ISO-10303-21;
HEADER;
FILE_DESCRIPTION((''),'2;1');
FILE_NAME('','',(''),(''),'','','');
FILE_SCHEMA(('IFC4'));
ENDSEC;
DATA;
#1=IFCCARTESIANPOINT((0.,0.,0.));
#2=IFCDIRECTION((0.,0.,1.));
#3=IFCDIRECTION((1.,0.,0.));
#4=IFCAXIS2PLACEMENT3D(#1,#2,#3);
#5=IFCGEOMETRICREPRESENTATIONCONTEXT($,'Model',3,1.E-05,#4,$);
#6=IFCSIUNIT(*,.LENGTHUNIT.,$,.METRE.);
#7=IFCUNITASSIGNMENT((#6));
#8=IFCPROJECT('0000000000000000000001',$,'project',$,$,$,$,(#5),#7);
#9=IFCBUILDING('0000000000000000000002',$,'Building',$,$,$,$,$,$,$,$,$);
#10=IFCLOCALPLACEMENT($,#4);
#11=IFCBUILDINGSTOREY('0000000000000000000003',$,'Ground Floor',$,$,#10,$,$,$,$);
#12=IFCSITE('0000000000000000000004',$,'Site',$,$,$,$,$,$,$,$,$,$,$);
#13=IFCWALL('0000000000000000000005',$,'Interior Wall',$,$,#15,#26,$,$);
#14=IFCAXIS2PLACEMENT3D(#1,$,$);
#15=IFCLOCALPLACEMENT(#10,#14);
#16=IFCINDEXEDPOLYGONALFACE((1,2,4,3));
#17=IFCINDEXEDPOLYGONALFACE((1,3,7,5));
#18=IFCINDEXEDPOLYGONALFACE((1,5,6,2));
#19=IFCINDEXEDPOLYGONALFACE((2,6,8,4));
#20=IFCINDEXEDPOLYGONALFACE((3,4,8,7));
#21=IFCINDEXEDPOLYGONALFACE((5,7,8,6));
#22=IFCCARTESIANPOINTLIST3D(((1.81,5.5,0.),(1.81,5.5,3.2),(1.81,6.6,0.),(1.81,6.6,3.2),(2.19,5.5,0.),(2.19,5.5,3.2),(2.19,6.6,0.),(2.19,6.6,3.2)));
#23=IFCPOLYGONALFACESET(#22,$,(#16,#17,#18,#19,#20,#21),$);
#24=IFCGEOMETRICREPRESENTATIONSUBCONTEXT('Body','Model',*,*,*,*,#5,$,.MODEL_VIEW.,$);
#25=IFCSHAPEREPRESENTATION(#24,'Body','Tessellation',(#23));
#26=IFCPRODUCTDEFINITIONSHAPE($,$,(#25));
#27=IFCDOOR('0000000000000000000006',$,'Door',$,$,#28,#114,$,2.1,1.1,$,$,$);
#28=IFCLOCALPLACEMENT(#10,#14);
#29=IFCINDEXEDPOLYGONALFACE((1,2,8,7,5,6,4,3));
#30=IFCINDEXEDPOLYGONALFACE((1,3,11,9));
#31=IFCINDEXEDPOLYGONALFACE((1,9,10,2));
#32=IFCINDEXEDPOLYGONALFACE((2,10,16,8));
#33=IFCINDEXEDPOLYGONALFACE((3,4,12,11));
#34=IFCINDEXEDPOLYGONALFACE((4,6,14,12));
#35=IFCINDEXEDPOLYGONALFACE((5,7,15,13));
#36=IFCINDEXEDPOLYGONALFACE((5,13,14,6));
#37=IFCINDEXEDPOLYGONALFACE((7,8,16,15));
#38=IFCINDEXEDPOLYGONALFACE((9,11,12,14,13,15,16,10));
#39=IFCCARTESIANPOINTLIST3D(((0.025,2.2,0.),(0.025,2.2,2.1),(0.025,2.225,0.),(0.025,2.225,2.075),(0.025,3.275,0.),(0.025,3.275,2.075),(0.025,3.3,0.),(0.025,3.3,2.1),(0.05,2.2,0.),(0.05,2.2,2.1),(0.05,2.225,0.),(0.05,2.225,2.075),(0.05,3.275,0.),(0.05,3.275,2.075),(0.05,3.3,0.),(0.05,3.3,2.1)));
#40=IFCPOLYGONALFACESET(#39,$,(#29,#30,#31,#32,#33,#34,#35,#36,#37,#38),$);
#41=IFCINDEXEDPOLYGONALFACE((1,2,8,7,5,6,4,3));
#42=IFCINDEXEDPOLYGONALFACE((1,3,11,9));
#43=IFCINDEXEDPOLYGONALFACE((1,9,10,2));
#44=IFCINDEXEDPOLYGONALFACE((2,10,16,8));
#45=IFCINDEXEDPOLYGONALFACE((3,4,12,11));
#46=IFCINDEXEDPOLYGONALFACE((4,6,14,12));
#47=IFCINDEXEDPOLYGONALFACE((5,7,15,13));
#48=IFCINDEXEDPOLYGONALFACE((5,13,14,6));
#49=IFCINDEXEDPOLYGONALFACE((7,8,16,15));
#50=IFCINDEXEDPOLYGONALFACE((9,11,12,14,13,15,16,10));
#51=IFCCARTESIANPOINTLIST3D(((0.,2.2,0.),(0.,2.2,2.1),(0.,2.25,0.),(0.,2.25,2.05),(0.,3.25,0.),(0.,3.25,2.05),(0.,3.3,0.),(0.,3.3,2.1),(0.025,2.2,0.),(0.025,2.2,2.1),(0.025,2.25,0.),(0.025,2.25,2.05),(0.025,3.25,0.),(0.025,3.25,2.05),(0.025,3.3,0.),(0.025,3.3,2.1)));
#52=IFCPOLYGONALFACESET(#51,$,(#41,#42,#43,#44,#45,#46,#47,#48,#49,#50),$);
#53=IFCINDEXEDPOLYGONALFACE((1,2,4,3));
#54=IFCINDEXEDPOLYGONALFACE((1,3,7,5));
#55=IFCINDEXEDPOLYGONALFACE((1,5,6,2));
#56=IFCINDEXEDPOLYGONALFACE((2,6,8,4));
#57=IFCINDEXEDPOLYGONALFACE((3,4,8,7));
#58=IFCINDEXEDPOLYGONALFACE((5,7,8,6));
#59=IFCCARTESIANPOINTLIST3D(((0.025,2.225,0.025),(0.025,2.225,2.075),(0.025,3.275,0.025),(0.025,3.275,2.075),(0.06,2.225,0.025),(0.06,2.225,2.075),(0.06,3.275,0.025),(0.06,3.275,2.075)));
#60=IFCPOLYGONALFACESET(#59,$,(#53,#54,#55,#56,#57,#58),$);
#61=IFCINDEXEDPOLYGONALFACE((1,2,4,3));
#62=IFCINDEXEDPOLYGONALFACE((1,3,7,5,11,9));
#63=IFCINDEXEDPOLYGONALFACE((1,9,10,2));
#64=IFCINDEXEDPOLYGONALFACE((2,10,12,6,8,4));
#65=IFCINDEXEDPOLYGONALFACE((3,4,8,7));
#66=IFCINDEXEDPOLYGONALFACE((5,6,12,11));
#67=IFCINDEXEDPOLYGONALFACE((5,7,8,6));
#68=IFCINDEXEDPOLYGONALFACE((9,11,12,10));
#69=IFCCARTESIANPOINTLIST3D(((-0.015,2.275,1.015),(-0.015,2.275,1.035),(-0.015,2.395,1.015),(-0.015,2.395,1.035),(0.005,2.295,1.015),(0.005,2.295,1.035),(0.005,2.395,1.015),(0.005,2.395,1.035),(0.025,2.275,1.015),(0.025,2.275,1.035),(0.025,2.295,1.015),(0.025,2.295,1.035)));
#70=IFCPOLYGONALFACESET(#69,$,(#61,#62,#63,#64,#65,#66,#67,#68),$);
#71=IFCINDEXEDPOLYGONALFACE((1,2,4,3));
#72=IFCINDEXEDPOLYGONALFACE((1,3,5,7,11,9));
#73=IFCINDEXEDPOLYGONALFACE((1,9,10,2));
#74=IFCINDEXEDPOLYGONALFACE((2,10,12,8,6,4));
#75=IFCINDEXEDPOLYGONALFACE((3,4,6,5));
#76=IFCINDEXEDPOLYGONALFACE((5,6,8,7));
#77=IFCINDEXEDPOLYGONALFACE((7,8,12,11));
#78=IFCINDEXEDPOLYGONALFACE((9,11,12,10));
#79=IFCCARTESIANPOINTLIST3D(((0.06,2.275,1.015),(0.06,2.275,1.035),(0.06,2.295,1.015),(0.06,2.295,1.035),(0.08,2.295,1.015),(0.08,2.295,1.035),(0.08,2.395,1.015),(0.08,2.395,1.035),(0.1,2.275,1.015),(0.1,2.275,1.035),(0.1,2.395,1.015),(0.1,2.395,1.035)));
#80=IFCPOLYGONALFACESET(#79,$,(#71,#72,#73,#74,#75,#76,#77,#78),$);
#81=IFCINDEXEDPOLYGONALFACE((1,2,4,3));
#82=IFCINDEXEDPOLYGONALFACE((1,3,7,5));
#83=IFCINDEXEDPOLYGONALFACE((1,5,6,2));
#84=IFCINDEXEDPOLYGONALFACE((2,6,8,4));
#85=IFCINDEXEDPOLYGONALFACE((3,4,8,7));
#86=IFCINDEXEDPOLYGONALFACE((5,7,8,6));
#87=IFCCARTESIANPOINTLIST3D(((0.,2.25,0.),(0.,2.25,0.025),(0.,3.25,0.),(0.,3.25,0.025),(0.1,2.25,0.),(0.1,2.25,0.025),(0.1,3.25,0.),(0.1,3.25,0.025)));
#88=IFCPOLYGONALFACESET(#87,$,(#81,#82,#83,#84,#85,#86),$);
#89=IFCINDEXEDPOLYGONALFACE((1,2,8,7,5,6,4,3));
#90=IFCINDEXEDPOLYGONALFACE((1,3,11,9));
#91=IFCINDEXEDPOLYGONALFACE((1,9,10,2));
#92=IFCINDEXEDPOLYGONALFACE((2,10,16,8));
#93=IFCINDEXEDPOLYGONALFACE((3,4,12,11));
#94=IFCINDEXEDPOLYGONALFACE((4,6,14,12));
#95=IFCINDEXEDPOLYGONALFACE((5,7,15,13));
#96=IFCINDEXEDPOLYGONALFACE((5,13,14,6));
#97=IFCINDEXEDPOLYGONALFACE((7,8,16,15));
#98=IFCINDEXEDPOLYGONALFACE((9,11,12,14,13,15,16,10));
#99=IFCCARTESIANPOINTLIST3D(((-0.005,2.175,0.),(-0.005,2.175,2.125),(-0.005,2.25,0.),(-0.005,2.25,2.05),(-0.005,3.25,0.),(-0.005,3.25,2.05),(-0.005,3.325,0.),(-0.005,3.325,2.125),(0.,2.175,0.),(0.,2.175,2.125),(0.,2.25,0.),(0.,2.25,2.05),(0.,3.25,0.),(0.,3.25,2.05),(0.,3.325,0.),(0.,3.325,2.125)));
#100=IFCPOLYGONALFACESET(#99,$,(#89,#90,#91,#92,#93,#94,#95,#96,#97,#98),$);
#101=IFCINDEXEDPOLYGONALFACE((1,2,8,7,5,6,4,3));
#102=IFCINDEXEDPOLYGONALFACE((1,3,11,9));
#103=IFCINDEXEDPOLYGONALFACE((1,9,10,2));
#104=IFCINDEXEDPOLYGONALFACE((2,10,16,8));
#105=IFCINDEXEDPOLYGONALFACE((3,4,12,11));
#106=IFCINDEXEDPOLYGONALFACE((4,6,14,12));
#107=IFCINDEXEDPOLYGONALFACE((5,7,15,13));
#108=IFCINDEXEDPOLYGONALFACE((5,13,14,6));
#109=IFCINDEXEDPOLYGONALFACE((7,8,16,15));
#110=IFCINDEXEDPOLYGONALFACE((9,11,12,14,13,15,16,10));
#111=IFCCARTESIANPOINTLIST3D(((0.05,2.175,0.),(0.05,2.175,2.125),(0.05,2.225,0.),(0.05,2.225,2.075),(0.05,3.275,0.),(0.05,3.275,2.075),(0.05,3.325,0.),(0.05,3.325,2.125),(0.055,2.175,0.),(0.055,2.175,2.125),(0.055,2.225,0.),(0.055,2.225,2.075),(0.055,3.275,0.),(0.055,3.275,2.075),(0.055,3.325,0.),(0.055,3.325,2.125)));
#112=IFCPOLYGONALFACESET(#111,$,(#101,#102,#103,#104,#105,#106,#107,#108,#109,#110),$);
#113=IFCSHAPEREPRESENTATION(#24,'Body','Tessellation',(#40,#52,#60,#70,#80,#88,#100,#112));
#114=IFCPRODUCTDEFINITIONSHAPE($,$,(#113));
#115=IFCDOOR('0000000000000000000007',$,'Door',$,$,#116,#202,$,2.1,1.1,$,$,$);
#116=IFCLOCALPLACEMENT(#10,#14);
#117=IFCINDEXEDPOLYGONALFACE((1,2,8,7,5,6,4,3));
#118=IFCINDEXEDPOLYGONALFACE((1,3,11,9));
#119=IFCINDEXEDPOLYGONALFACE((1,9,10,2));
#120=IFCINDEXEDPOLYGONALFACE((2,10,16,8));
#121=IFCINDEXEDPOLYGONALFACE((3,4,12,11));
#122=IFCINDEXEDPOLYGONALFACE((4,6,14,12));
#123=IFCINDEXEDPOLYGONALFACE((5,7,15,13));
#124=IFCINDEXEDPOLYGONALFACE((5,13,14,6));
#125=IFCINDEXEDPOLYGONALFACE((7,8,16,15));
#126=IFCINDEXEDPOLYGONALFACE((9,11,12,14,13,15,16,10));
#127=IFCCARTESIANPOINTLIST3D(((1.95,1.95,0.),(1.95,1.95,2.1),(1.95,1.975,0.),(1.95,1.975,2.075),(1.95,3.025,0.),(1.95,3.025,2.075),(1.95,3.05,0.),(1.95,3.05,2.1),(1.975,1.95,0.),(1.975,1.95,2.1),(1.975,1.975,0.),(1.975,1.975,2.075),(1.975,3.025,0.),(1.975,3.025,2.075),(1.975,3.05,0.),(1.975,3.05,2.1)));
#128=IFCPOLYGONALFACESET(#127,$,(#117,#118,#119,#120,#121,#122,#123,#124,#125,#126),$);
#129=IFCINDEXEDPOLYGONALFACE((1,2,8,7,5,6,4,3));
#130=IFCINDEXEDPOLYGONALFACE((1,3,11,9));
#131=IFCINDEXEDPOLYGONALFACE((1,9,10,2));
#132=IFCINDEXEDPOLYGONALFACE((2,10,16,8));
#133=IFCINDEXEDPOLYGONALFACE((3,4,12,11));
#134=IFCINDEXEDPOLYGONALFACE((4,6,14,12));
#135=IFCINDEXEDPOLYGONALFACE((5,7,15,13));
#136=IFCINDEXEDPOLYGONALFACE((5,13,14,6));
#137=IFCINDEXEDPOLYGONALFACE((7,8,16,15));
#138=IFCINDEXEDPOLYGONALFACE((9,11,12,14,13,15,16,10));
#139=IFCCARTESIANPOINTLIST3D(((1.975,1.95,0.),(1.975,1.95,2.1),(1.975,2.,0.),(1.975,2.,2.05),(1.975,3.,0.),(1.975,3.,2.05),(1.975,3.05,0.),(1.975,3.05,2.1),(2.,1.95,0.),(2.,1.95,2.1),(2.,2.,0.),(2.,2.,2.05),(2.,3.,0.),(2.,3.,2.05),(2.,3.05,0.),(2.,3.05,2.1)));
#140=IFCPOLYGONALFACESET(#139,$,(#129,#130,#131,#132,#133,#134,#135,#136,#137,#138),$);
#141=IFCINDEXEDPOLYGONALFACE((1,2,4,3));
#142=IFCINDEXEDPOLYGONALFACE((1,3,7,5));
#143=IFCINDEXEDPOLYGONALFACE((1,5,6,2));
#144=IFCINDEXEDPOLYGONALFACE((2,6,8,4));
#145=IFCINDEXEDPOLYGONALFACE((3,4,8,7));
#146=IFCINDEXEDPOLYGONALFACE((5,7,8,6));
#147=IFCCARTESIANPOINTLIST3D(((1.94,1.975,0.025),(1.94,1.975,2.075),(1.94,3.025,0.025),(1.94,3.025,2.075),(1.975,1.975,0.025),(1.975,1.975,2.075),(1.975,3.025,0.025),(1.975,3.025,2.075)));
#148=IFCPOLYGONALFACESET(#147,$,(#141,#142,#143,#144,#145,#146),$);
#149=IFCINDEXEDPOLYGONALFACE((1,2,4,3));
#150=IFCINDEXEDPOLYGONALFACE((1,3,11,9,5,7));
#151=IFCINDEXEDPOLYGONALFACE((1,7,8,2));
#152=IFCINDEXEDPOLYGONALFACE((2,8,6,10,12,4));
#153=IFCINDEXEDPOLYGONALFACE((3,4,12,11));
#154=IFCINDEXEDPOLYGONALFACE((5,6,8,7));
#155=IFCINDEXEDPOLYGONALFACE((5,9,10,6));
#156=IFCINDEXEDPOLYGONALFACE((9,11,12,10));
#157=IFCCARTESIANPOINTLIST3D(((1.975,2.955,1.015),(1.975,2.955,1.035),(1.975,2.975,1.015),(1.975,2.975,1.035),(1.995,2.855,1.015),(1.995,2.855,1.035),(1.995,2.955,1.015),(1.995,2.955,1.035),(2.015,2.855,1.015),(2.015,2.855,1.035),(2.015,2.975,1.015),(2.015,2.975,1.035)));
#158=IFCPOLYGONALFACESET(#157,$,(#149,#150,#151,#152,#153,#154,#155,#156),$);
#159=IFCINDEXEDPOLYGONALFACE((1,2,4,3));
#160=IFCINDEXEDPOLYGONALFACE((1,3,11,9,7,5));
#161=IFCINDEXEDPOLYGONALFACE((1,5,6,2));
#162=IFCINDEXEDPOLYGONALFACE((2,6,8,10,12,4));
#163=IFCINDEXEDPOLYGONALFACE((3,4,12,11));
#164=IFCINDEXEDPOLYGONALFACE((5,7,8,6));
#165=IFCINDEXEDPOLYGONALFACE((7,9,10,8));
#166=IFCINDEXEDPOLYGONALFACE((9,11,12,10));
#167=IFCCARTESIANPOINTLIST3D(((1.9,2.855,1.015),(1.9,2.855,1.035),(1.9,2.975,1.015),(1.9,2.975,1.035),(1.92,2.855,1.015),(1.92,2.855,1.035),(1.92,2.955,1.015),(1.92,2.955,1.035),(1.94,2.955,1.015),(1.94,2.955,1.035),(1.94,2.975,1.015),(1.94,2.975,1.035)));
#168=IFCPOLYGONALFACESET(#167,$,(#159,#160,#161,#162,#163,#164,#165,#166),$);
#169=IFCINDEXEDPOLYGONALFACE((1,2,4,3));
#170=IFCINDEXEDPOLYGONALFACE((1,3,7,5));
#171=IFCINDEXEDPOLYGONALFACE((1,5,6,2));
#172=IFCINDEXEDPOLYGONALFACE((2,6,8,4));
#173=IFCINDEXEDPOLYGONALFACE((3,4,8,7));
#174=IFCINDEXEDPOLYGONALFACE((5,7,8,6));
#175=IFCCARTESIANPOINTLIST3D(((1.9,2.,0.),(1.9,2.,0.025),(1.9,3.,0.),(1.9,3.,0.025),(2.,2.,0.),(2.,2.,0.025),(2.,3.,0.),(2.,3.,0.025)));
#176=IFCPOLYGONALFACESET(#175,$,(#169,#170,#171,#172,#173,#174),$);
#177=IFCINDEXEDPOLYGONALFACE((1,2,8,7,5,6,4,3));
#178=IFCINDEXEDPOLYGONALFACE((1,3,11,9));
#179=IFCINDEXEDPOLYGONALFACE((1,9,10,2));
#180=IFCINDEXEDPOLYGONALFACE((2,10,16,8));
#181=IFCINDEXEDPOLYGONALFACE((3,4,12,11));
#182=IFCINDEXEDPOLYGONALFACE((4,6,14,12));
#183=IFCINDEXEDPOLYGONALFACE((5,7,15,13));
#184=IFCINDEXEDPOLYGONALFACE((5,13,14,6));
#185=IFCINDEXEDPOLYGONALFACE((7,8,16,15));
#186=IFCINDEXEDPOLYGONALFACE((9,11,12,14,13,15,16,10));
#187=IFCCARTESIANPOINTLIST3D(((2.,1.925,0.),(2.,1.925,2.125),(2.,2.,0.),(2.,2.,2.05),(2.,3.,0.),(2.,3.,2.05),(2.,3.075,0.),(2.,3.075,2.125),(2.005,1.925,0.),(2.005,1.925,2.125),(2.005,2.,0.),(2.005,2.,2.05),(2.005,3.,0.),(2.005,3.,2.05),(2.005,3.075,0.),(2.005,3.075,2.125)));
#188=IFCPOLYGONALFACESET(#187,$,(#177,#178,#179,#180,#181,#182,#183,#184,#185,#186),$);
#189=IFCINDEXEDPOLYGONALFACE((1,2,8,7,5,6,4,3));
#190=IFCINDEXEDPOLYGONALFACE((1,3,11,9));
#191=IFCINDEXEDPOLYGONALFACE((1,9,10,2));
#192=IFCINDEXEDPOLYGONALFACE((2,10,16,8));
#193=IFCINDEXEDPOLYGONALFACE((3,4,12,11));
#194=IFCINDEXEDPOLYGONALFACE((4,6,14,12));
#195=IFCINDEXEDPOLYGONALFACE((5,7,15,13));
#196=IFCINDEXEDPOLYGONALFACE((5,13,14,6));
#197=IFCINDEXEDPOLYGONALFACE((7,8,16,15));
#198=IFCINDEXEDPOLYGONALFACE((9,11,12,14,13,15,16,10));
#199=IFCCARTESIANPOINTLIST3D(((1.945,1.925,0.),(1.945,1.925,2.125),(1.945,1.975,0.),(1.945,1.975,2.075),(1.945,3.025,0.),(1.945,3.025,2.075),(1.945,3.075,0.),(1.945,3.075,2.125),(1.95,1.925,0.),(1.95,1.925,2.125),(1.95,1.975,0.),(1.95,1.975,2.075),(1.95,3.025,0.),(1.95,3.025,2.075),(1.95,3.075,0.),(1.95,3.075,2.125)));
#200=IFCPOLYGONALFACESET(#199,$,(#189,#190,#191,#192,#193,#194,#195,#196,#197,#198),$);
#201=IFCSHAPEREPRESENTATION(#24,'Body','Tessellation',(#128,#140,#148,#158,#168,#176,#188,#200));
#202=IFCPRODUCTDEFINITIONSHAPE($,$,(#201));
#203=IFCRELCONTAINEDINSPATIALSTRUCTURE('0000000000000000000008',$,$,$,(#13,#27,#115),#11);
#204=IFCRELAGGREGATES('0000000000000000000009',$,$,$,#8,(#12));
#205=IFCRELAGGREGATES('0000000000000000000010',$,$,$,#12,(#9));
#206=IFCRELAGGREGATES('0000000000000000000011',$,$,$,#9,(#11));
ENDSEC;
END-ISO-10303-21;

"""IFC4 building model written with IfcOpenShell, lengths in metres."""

from ifc_helpers import new_model, si_unit, frame, origin_with_axes, place, context, subcontext, project, spatial, line, indexed_curve, outline, extrude, element, save


model = new_model("IFC4")

# Units and contexts
model_context = context("Model", 3, precision=1e-05, world=origin_with_axes())
body_context = subcontext(model_context, "Body", "Model", "MODEL_VIEW")
ifc_project = project(units=[si_unit("LENGTHUNIT", "METRE")], contexts=[model_context])

# Site, building, storey
site = spatial("IfcSite", under=ifc_project, Name="Site")
building = spatial("IfcBuilding", under=site, Name="Building")
storey_placement = place(None, origin_with_axes())
storey = spatial("IfcBuildingStorey", under=building, at=storey_placement, Name="Ground Floor")

# Wall
wall_1_placement = place(storey_placement, frame((2.0, 6.6, 0.0), z_axis=(0.0, 0.0, 1.0), x_axis=(0.0, -1.0, 0.0)))
element("IfcWall", 1, at=wall_1_placement, inside=storey, Name="Interior Wall", context=body_context, shape_type="SweptSolid", body=[
    extrude(outline(indexed_curve([(0.0, 0.0), (0.0, 0.38), (1.1, 0.38), (1.1, 0.0), (0.0, 0.0)], self_intersect=False)), frame((0.0, -0.19, 0.0), z_axis=(0.0, 0.0, 1.0), x_axis=(1.0, 0.0, 0.0)), (0.0, 0.0, 1.0), 3.2),
])

# Doors
door_1_placement = place(storey_placement, frame((0.0, 3.3, 0.0), z_axis=(0.0, 0.0, 1.0), x_axis=(0.0, -1.0, 0.0)))
element("IfcDoor", 2, at=door_1_placement, inside=storey, Name="Door", OverallHeight=2.1, OverallWidth=1.1, context=body_context, shape_type="SweptSolid", body=[
    extrude(outline(indexed_curve([(0.0, 0.0), (0.0, 2.1), (1.1, 2.1), (1.1, 0.0), (1.075, 0.0), (1.075, 2.075), (0.025, 2.075), (0.025, 0.0)], segments=[line(1, 2, 3, 4, 5, 6, 7, 8, 1)])), frame((0.0, 0.025, 0.0), z_axis=(0.0, -1.0, 0.0), x_axis=(1.0, 0.0, 0.0)), (0.0, 0.0, -1.0), 0.025),
    extrude(outline(indexed_curve([(0.0, 0.0), (0.0, 2.1), (1.1, 2.1), (1.1, 0.0), (1.05, 0.0), (1.05, 2.05), (0.05, 2.05), (0.05, 0.0)], segments=[line(1, 2, 3, 4, 5, 6, 7, 8, 1)])), frame((0.0, 0.0, 0.0), z_axis=(0.0, -1.0, 0.0), x_axis=(1.0, 0.0, 0.0)), (0.0, 0.0, -1.0), 0.025),
    extrude(outline(indexed_curve([(0.0, 0.0), (1.05, 0.0), (1.05, 0.035), (0.0, 0.035)], segments=[line(1, 2, 3, 4, 1)])), frame((0.025, 0.025, 0.025), z_axis=(0.0, 0.0, 1.0), x_axis=(1.0, 0.0, 0.0)), (0.0, 0.0, 1.0), 2.05),
    extrude(outline(indexed_curve([(0.0, 0.0), (0.0, -0.04), (-0.12, -0.04), (-0.12, -0.02), (-0.02, -0.02), (-0.02, 0.0)], segments=[line(1, 2, 3, 4, 5, 6, 1)])), frame((1.025, 0.025, 1.015), z_axis=(0.0, 0.0, 1.0), x_axis=(1.0, 0.0, 0.0)), (0.0, 0.0, 1.0), 0.02),
    extrude(outline(indexed_curve([(0.0, 0.0), (0.0, 0.04), (-0.12, 0.04), (-0.12, 0.02), (-0.02, 0.02), (-0.02, 0.0)], segments=[line(1, 2, 3, 4, 5, 6, 1)])), frame((1.025, 0.06, 1.015), z_axis=(0.0, 0.0, 1.0), x_axis=(1.0, 0.0, 0.0)), (0.0, 0.0, 1.0), 0.02),
    extrude(outline(indexed_curve([(0.0, 0.0), (1.0, 0.0), (1.0, 0.1), (0.0, 0.1)], segments=[line(1, 2, 3, 4, 1)])), frame((0.05, 0.0, 0.0), z_axis=(0.0, 0.0, 1.0), x_axis=(1.0, 0.0, 0.0)), (0.0, 0.0, 1.0), 0.025),
    extrude(outline(indexed_curve([(0.0, 0.0), (0.0, 2.125), (1.15, 2.125), (1.15, 0.0), (1.075, 0.0), (1.075, 2.05), (0.075, 2.05), (0.075, 0.0)], segments=[line(1, 2, 3, 4, 5, 6, 7, 8, 1)])), frame((-0.025, -0.005, 0.0), z_axis=(0.0, -1.0, 0.0), x_axis=(1.0, 0.0, 0.0)), (0.0, 0.0, -1.0), 0.005),
    extrude(outline(indexed_curve([(0.0, 0.0), (0.0, 2.125), (1.15, 2.125), (1.15, 0.0), (1.1, 0.0), (1.1, 2.075), (0.05, 2.075), (0.05, 0.0)], segments=[line(1, 2, 3, 4, 5, 6, 7, 8, 1)])), frame((-0.025, 0.05, 0.0), z_axis=(0.0, -1.0, 0.0), x_axis=(1.0, 0.0, 0.0)), (0.0, 0.0, -1.0), 0.005),
])
door_2_placement = place(storey_placement, frame((2.0, 1.95, 0.0), z_axis=(0.0, 0.0, 1.0), x_axis=(0.0, 1.0, 0.0)))
element("IfcDoor", 3, at=door_2_placement, inside=storey, Name="Door", OverallHeight=2.1, OverallWidth=1.1, context=body_context, shape_type="SweptSolid", body=[
    extrude(outline(indexed_curve([(0.0, 0.0), (0.0, 2.1), (1.1, 2.1), (1.1, 0.0), (1.075, 0.0), (1.075, 2.075), (0.025, 2.075), (0.025, 0.0)], segments=[line(1, 2, 3, 4, 5, 6, 7, 8, 1)])), frame((0.0, 0.025, 0.0), z_axis=(0.0, -1.0, 0.0), x_axis=(1.0, 0.0, 0.0)), (0.0, 0.0, -1.0), 0.025),
    extrude(outline(indexed_curve([(0.0, 0.0), (0.0, 2.1), (1.1, 2.1), (1.1, 0.0), (1.05, 0.0), (1.05, 2.05), (0.05, 2.05), (0.05, 0.0)], segments=[line(1, 2, 3, 4, 5, 6, 7, 8, 1)])), frame((0.0, 0.0, 0.0), z_axis=(0.0, -1.0, 0.0), x_axis=(1.0, 0.0, 0.0)), (0.0, 0.0, -1.0), 0.025),
    extrude(outline(indexed_curve([(0.0, 0.0), (1.05, 0.0), (1.05, 0.035), (0.0, 0.035)], segments=[line(1, 2, 3, 4, 1)])), frame((0.025, 0.025, 0.025), z_axis=(0.0, 0.0, 1.0), x_axis=(1.0, 0.0, 0.0)), (0.0, 0.0, 1.0), 2.05),
    extrude(outline(indexed_curve([(0.0, 0.0), (0.0, -0.04), (-0.12, -0.04), (-0.12, -0.02), (-0.02, -0.02), (-0.02, 0.0)], segments=[line(1, 2, 3, 4, 5, 6, 1)])), frame((1.025, 0.025, 1.015), z_axis=(0.0, 0.0, 1.0), x_axis=(1.0, 0.0, 0.0)), (0.0, 0.0, 1.0), 0.02),
    extrude(outline(indexed_curve([(0.0, 0.0), (0.0, 0.04), (-0.12, 0.04), (-0.12, 0.02), (-0.02, 0.02), (-0.02, 0.0)], segments=[line(1, 2, 3, 4, 5, 6, 1)])), frame((1.025, 0.06, 1.015), z_axis=(0.0, 0.0, 1.0), x_axis=(1.0, 0.0, 0.0)), (0.0, 0.0, 1.0), 0.02),
    extrude(outline(indexed_curve([(0.0, 0.0), (1.0, 0.0), (1.0, 0.1), (0.0, 0.1)], segments=[line(1, 2, 3, 4, 1)])), frame((0.05, 0.0, 0.0), z_axis=(0.0, 0.0, 1.0), x_axis=(1.0, 0.0, 0.0)), (0.0, 0.0, 1.0), 0.025),
    extrude(outline(indexed_curve([(0.0, 0.0), (0.0, 2.125), (1.15, 2.125), (1.15, 0.0), (1.075, 0.0), (1.075, 2.05), (0.075, 2.05), (0.075, 0.0)], segments=[line(1, 2, 3, 4, 5, 6, 7, 8, 1)])), frame((-0.025, -0.005, 0.0), z_axis=(0.0, -1.0, 0.0), x_axis=(1.0, 0.0, 0.0)), (0.0, 0.0, -1.0), 0.005),
    extrude(outline(indexed_curve([(0.0, 0.0), (0.0, 2.125), (1.15, 2.125), (1.15, 0.0), (1.1, 0.0), (1.1, 2.075), (0.05, 2.075), (0.05, 0.0)], segments=[line(1, 2, 3, 4, 5, 6, 7, 8, 1)])), frame((-0.025, 0.05, 0.0), z_axis=(0.0, -1.0, 0.0), x_axis=(1.0, 0.0, 0.0)), (0.0, 0.0, -1.0), 0.005),
])

save(model, "model.ifc")
